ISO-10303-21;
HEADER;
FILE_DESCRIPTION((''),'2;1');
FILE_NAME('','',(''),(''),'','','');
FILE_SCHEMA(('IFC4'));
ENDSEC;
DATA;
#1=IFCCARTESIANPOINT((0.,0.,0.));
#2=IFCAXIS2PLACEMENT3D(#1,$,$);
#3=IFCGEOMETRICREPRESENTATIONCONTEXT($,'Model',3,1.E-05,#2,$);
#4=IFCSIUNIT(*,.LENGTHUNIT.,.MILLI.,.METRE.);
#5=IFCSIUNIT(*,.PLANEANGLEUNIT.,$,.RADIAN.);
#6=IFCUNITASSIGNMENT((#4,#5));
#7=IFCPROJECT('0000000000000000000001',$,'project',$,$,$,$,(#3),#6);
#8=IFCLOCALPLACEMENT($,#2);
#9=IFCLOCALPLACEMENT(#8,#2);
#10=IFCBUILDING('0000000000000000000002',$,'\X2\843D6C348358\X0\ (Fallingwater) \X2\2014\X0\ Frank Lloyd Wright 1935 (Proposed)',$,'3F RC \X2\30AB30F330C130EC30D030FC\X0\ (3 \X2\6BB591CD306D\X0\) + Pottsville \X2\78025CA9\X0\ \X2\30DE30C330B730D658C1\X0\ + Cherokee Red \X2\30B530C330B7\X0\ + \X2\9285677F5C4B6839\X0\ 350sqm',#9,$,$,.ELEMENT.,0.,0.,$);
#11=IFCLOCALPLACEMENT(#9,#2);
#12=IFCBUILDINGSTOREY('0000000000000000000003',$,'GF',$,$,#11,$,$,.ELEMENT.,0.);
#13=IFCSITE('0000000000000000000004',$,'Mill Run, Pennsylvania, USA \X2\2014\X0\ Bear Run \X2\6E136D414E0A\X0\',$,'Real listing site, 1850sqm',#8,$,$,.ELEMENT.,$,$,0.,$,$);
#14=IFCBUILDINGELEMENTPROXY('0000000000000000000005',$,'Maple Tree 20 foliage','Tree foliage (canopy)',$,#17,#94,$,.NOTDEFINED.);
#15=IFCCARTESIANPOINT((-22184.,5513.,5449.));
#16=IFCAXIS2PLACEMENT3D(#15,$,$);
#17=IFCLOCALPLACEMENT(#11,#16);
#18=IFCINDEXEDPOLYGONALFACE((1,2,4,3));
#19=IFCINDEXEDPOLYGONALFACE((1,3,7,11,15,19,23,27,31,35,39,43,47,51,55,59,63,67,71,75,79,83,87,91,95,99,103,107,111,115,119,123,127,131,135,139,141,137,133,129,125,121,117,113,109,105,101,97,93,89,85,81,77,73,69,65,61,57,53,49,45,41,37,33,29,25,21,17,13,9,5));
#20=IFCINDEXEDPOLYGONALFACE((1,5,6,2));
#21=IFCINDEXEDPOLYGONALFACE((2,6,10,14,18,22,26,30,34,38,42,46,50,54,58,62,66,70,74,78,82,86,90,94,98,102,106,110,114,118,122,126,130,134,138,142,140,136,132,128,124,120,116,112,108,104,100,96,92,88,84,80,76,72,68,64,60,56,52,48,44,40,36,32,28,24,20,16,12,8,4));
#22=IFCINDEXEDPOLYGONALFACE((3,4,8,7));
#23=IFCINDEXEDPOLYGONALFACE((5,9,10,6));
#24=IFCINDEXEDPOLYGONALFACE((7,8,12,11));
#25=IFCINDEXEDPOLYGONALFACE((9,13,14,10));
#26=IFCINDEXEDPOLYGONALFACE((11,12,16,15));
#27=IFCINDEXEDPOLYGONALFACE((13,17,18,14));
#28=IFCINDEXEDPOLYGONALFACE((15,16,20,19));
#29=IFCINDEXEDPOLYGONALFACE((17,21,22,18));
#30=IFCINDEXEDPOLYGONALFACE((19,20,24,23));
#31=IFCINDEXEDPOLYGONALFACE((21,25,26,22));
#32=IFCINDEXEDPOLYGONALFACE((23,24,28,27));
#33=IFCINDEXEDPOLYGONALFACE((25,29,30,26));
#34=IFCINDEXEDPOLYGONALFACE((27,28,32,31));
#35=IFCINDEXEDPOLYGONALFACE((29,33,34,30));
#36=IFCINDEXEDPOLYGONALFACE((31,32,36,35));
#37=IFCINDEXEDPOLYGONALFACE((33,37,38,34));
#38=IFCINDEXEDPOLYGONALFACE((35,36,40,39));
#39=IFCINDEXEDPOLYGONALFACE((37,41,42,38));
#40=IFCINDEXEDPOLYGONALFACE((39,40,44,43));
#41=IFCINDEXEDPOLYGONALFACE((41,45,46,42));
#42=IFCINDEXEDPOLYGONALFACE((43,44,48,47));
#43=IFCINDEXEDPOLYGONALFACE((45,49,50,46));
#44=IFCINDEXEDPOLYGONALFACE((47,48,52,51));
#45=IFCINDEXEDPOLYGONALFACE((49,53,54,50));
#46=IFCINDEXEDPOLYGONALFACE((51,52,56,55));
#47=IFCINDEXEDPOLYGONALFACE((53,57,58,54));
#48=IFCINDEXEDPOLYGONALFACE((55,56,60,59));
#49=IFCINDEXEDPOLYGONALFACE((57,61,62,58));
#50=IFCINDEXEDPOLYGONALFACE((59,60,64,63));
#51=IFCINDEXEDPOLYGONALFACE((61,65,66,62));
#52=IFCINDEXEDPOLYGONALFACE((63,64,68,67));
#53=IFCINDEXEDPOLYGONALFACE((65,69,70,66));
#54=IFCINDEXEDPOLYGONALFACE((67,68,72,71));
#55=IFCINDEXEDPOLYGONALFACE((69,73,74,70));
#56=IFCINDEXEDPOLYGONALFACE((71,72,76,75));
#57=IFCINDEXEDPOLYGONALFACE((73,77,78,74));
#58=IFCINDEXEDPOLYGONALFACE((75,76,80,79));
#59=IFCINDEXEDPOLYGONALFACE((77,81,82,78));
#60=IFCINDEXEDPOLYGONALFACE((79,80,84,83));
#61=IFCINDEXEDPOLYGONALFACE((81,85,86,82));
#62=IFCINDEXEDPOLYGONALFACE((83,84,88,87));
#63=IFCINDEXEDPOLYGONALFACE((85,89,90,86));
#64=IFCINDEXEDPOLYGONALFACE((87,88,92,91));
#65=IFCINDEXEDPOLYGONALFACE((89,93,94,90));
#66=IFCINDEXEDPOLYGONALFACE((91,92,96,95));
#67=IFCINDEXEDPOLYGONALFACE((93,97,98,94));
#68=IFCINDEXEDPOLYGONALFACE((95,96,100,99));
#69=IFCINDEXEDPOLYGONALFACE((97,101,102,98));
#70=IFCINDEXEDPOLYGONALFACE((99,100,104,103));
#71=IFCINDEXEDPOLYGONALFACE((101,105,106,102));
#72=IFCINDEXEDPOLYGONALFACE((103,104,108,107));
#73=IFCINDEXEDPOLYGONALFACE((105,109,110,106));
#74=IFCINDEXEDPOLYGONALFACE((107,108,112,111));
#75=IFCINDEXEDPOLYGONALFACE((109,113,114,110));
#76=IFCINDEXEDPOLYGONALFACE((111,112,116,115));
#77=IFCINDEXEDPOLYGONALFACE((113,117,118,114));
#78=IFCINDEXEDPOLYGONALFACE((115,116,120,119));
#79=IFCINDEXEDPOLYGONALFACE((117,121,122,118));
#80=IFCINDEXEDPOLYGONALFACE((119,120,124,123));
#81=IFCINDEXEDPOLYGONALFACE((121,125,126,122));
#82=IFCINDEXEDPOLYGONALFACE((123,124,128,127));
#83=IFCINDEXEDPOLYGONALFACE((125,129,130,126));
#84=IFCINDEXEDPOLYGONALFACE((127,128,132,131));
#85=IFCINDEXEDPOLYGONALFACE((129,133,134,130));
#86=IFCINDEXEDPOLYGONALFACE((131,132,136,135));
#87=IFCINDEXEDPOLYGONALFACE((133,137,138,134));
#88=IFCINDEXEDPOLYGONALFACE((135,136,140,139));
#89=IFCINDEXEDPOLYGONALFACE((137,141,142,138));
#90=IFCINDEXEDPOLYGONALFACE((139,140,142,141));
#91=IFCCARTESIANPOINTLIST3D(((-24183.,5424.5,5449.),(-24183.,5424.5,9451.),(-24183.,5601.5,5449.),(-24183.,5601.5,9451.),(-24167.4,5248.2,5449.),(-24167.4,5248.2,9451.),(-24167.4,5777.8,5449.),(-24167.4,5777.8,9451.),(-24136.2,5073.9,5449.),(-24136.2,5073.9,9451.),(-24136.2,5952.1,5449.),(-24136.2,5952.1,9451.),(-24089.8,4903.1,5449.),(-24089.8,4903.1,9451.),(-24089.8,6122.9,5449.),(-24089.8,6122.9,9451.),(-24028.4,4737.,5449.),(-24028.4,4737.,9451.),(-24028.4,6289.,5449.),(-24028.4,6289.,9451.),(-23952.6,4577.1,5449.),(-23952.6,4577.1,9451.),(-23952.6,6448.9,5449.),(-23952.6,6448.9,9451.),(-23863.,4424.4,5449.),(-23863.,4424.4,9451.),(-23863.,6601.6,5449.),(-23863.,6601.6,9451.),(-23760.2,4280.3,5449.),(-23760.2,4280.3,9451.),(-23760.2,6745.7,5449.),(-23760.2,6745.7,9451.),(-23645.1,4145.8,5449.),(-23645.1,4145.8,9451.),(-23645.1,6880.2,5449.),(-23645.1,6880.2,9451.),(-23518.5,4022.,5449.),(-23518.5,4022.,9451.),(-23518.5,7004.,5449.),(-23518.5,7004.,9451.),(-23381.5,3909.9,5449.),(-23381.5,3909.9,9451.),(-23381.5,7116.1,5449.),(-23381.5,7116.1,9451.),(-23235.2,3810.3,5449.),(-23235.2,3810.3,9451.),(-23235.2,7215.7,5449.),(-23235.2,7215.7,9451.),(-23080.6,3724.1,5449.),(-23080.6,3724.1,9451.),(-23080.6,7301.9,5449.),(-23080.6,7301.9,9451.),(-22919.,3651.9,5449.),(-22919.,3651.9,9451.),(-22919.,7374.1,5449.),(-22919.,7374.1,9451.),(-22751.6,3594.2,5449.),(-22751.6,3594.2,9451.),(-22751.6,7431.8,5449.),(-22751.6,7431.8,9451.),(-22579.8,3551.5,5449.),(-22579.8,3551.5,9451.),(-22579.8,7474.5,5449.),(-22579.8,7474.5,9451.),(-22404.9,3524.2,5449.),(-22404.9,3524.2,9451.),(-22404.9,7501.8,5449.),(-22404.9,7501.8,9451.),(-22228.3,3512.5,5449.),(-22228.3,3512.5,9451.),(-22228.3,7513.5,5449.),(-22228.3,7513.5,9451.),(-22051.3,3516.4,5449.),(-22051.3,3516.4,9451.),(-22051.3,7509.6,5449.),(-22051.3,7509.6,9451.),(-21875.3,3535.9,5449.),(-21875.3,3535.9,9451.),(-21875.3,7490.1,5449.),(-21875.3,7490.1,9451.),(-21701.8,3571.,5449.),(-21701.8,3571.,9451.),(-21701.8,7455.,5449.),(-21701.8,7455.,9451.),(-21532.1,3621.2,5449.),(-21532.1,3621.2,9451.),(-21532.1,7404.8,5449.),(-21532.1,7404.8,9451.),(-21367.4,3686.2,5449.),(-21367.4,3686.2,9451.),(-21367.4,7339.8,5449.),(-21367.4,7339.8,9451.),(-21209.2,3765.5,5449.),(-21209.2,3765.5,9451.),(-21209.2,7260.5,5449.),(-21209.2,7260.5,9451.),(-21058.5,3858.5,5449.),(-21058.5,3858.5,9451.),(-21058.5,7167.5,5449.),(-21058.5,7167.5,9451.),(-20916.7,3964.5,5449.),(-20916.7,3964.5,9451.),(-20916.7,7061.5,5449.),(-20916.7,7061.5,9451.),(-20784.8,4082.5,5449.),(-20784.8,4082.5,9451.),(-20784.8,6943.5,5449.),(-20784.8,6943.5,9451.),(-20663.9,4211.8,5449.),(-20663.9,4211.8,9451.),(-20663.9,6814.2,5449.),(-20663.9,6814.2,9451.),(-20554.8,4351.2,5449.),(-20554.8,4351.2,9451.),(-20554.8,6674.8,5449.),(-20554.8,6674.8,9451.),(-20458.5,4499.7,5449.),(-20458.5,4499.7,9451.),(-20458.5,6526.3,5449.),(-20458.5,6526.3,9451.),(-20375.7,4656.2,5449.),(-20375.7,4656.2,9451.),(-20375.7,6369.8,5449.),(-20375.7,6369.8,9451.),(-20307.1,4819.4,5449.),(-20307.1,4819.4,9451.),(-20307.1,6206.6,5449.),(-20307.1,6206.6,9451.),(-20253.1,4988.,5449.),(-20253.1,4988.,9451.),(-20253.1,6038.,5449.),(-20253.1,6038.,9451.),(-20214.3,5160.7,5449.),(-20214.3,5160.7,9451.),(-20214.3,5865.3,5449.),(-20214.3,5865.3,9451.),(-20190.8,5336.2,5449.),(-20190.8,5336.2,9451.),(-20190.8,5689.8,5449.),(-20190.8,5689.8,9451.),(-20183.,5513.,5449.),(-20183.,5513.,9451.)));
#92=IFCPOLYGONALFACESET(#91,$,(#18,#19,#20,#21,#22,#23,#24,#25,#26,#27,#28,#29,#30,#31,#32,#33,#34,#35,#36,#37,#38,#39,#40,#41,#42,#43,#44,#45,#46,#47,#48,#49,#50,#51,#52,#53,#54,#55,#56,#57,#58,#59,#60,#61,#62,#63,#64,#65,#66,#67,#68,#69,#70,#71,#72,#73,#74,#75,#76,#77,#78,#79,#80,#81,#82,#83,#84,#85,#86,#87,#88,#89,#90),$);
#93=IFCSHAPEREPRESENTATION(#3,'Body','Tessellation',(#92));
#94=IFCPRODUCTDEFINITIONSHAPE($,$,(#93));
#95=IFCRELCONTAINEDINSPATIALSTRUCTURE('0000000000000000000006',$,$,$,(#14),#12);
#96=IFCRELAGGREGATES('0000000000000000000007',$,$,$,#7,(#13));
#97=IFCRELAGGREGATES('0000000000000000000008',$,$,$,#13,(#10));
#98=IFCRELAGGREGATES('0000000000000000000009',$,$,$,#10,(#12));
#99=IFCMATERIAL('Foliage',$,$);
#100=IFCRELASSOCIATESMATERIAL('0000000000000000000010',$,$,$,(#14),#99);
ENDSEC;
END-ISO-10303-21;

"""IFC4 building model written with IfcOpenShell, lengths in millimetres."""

from ifc_helpers import new_model, si_unit, frame, origin, origin_2d, place, context, project, spatial, circle, extrude, material, element, save


model = new_model("IFC4")

# Units and contexts
model_context = context("Model", 3, precision=1e-05, world=origin())
ifc_project = project(units=[si_unit("LENGTHUNIT", "METRE", prefix="MILLI"), si_unit("PLANEANGLEUNIT", "RADIAN")], contexts=[model_context])

# Site, building, storey
site_placement = place(None, origin())
site = spatial("IfcSite", under=ifc_project, at=site_placement, Name="Mill Run, Pennsylvania, USA — Bear Run 渓流上", ObjectType="Real listing site, 1850sqm", CompositionType="ELEMENT", RefElevation=0.0)
building_placement = place(site_placement, origin())
building = spatial("IfcBuilding", under=site, at=building_placement, Name="落水荘 (Fallingwater) — Frank Lloyd Wright 1935 (Proposed)", ObjectType="3F RC カンチレバー (3 段重ね) + Pottsville 砂岩 マッシブ壁 + Cherokee Red サッシ + 銅板屋根 350sqm", CompositionType="ELEMENT", ElevationOfRefHeight=0.0, ElevationOfTerrain=0.0)
storey_placement = place(building_placement, origin())
storey = spatial("IfcBuildingStorey", under=building, at=storey_placement, Name="GF", CompositionType="ELEMENT", Elevation=0.0)

# Building element proxy
ifc_material_1 = material(Name="Foliage")
proxy_1_placement = place(storey_placement, frame((-22184.0, 5513.0, 5449.0)))
element("IfcBuildingElementProxy", 1, at=proxy_1_placement, inside=storey, material=ifc_material_1, Name="Maple Tree 20 foliage", Description="Tree foliage (canopy)", PredefinedType="NOTDEFINED", context=model_context, shape_type="SweptSolid", body=[
    extrude(circle(Radius=2001.0, at=origin_2d()), frame((-22184.0, 5513.0, 5449.0)), (0.0, 0.0, 1.0), 4002.0),
])

save(model, "model.ifc")
